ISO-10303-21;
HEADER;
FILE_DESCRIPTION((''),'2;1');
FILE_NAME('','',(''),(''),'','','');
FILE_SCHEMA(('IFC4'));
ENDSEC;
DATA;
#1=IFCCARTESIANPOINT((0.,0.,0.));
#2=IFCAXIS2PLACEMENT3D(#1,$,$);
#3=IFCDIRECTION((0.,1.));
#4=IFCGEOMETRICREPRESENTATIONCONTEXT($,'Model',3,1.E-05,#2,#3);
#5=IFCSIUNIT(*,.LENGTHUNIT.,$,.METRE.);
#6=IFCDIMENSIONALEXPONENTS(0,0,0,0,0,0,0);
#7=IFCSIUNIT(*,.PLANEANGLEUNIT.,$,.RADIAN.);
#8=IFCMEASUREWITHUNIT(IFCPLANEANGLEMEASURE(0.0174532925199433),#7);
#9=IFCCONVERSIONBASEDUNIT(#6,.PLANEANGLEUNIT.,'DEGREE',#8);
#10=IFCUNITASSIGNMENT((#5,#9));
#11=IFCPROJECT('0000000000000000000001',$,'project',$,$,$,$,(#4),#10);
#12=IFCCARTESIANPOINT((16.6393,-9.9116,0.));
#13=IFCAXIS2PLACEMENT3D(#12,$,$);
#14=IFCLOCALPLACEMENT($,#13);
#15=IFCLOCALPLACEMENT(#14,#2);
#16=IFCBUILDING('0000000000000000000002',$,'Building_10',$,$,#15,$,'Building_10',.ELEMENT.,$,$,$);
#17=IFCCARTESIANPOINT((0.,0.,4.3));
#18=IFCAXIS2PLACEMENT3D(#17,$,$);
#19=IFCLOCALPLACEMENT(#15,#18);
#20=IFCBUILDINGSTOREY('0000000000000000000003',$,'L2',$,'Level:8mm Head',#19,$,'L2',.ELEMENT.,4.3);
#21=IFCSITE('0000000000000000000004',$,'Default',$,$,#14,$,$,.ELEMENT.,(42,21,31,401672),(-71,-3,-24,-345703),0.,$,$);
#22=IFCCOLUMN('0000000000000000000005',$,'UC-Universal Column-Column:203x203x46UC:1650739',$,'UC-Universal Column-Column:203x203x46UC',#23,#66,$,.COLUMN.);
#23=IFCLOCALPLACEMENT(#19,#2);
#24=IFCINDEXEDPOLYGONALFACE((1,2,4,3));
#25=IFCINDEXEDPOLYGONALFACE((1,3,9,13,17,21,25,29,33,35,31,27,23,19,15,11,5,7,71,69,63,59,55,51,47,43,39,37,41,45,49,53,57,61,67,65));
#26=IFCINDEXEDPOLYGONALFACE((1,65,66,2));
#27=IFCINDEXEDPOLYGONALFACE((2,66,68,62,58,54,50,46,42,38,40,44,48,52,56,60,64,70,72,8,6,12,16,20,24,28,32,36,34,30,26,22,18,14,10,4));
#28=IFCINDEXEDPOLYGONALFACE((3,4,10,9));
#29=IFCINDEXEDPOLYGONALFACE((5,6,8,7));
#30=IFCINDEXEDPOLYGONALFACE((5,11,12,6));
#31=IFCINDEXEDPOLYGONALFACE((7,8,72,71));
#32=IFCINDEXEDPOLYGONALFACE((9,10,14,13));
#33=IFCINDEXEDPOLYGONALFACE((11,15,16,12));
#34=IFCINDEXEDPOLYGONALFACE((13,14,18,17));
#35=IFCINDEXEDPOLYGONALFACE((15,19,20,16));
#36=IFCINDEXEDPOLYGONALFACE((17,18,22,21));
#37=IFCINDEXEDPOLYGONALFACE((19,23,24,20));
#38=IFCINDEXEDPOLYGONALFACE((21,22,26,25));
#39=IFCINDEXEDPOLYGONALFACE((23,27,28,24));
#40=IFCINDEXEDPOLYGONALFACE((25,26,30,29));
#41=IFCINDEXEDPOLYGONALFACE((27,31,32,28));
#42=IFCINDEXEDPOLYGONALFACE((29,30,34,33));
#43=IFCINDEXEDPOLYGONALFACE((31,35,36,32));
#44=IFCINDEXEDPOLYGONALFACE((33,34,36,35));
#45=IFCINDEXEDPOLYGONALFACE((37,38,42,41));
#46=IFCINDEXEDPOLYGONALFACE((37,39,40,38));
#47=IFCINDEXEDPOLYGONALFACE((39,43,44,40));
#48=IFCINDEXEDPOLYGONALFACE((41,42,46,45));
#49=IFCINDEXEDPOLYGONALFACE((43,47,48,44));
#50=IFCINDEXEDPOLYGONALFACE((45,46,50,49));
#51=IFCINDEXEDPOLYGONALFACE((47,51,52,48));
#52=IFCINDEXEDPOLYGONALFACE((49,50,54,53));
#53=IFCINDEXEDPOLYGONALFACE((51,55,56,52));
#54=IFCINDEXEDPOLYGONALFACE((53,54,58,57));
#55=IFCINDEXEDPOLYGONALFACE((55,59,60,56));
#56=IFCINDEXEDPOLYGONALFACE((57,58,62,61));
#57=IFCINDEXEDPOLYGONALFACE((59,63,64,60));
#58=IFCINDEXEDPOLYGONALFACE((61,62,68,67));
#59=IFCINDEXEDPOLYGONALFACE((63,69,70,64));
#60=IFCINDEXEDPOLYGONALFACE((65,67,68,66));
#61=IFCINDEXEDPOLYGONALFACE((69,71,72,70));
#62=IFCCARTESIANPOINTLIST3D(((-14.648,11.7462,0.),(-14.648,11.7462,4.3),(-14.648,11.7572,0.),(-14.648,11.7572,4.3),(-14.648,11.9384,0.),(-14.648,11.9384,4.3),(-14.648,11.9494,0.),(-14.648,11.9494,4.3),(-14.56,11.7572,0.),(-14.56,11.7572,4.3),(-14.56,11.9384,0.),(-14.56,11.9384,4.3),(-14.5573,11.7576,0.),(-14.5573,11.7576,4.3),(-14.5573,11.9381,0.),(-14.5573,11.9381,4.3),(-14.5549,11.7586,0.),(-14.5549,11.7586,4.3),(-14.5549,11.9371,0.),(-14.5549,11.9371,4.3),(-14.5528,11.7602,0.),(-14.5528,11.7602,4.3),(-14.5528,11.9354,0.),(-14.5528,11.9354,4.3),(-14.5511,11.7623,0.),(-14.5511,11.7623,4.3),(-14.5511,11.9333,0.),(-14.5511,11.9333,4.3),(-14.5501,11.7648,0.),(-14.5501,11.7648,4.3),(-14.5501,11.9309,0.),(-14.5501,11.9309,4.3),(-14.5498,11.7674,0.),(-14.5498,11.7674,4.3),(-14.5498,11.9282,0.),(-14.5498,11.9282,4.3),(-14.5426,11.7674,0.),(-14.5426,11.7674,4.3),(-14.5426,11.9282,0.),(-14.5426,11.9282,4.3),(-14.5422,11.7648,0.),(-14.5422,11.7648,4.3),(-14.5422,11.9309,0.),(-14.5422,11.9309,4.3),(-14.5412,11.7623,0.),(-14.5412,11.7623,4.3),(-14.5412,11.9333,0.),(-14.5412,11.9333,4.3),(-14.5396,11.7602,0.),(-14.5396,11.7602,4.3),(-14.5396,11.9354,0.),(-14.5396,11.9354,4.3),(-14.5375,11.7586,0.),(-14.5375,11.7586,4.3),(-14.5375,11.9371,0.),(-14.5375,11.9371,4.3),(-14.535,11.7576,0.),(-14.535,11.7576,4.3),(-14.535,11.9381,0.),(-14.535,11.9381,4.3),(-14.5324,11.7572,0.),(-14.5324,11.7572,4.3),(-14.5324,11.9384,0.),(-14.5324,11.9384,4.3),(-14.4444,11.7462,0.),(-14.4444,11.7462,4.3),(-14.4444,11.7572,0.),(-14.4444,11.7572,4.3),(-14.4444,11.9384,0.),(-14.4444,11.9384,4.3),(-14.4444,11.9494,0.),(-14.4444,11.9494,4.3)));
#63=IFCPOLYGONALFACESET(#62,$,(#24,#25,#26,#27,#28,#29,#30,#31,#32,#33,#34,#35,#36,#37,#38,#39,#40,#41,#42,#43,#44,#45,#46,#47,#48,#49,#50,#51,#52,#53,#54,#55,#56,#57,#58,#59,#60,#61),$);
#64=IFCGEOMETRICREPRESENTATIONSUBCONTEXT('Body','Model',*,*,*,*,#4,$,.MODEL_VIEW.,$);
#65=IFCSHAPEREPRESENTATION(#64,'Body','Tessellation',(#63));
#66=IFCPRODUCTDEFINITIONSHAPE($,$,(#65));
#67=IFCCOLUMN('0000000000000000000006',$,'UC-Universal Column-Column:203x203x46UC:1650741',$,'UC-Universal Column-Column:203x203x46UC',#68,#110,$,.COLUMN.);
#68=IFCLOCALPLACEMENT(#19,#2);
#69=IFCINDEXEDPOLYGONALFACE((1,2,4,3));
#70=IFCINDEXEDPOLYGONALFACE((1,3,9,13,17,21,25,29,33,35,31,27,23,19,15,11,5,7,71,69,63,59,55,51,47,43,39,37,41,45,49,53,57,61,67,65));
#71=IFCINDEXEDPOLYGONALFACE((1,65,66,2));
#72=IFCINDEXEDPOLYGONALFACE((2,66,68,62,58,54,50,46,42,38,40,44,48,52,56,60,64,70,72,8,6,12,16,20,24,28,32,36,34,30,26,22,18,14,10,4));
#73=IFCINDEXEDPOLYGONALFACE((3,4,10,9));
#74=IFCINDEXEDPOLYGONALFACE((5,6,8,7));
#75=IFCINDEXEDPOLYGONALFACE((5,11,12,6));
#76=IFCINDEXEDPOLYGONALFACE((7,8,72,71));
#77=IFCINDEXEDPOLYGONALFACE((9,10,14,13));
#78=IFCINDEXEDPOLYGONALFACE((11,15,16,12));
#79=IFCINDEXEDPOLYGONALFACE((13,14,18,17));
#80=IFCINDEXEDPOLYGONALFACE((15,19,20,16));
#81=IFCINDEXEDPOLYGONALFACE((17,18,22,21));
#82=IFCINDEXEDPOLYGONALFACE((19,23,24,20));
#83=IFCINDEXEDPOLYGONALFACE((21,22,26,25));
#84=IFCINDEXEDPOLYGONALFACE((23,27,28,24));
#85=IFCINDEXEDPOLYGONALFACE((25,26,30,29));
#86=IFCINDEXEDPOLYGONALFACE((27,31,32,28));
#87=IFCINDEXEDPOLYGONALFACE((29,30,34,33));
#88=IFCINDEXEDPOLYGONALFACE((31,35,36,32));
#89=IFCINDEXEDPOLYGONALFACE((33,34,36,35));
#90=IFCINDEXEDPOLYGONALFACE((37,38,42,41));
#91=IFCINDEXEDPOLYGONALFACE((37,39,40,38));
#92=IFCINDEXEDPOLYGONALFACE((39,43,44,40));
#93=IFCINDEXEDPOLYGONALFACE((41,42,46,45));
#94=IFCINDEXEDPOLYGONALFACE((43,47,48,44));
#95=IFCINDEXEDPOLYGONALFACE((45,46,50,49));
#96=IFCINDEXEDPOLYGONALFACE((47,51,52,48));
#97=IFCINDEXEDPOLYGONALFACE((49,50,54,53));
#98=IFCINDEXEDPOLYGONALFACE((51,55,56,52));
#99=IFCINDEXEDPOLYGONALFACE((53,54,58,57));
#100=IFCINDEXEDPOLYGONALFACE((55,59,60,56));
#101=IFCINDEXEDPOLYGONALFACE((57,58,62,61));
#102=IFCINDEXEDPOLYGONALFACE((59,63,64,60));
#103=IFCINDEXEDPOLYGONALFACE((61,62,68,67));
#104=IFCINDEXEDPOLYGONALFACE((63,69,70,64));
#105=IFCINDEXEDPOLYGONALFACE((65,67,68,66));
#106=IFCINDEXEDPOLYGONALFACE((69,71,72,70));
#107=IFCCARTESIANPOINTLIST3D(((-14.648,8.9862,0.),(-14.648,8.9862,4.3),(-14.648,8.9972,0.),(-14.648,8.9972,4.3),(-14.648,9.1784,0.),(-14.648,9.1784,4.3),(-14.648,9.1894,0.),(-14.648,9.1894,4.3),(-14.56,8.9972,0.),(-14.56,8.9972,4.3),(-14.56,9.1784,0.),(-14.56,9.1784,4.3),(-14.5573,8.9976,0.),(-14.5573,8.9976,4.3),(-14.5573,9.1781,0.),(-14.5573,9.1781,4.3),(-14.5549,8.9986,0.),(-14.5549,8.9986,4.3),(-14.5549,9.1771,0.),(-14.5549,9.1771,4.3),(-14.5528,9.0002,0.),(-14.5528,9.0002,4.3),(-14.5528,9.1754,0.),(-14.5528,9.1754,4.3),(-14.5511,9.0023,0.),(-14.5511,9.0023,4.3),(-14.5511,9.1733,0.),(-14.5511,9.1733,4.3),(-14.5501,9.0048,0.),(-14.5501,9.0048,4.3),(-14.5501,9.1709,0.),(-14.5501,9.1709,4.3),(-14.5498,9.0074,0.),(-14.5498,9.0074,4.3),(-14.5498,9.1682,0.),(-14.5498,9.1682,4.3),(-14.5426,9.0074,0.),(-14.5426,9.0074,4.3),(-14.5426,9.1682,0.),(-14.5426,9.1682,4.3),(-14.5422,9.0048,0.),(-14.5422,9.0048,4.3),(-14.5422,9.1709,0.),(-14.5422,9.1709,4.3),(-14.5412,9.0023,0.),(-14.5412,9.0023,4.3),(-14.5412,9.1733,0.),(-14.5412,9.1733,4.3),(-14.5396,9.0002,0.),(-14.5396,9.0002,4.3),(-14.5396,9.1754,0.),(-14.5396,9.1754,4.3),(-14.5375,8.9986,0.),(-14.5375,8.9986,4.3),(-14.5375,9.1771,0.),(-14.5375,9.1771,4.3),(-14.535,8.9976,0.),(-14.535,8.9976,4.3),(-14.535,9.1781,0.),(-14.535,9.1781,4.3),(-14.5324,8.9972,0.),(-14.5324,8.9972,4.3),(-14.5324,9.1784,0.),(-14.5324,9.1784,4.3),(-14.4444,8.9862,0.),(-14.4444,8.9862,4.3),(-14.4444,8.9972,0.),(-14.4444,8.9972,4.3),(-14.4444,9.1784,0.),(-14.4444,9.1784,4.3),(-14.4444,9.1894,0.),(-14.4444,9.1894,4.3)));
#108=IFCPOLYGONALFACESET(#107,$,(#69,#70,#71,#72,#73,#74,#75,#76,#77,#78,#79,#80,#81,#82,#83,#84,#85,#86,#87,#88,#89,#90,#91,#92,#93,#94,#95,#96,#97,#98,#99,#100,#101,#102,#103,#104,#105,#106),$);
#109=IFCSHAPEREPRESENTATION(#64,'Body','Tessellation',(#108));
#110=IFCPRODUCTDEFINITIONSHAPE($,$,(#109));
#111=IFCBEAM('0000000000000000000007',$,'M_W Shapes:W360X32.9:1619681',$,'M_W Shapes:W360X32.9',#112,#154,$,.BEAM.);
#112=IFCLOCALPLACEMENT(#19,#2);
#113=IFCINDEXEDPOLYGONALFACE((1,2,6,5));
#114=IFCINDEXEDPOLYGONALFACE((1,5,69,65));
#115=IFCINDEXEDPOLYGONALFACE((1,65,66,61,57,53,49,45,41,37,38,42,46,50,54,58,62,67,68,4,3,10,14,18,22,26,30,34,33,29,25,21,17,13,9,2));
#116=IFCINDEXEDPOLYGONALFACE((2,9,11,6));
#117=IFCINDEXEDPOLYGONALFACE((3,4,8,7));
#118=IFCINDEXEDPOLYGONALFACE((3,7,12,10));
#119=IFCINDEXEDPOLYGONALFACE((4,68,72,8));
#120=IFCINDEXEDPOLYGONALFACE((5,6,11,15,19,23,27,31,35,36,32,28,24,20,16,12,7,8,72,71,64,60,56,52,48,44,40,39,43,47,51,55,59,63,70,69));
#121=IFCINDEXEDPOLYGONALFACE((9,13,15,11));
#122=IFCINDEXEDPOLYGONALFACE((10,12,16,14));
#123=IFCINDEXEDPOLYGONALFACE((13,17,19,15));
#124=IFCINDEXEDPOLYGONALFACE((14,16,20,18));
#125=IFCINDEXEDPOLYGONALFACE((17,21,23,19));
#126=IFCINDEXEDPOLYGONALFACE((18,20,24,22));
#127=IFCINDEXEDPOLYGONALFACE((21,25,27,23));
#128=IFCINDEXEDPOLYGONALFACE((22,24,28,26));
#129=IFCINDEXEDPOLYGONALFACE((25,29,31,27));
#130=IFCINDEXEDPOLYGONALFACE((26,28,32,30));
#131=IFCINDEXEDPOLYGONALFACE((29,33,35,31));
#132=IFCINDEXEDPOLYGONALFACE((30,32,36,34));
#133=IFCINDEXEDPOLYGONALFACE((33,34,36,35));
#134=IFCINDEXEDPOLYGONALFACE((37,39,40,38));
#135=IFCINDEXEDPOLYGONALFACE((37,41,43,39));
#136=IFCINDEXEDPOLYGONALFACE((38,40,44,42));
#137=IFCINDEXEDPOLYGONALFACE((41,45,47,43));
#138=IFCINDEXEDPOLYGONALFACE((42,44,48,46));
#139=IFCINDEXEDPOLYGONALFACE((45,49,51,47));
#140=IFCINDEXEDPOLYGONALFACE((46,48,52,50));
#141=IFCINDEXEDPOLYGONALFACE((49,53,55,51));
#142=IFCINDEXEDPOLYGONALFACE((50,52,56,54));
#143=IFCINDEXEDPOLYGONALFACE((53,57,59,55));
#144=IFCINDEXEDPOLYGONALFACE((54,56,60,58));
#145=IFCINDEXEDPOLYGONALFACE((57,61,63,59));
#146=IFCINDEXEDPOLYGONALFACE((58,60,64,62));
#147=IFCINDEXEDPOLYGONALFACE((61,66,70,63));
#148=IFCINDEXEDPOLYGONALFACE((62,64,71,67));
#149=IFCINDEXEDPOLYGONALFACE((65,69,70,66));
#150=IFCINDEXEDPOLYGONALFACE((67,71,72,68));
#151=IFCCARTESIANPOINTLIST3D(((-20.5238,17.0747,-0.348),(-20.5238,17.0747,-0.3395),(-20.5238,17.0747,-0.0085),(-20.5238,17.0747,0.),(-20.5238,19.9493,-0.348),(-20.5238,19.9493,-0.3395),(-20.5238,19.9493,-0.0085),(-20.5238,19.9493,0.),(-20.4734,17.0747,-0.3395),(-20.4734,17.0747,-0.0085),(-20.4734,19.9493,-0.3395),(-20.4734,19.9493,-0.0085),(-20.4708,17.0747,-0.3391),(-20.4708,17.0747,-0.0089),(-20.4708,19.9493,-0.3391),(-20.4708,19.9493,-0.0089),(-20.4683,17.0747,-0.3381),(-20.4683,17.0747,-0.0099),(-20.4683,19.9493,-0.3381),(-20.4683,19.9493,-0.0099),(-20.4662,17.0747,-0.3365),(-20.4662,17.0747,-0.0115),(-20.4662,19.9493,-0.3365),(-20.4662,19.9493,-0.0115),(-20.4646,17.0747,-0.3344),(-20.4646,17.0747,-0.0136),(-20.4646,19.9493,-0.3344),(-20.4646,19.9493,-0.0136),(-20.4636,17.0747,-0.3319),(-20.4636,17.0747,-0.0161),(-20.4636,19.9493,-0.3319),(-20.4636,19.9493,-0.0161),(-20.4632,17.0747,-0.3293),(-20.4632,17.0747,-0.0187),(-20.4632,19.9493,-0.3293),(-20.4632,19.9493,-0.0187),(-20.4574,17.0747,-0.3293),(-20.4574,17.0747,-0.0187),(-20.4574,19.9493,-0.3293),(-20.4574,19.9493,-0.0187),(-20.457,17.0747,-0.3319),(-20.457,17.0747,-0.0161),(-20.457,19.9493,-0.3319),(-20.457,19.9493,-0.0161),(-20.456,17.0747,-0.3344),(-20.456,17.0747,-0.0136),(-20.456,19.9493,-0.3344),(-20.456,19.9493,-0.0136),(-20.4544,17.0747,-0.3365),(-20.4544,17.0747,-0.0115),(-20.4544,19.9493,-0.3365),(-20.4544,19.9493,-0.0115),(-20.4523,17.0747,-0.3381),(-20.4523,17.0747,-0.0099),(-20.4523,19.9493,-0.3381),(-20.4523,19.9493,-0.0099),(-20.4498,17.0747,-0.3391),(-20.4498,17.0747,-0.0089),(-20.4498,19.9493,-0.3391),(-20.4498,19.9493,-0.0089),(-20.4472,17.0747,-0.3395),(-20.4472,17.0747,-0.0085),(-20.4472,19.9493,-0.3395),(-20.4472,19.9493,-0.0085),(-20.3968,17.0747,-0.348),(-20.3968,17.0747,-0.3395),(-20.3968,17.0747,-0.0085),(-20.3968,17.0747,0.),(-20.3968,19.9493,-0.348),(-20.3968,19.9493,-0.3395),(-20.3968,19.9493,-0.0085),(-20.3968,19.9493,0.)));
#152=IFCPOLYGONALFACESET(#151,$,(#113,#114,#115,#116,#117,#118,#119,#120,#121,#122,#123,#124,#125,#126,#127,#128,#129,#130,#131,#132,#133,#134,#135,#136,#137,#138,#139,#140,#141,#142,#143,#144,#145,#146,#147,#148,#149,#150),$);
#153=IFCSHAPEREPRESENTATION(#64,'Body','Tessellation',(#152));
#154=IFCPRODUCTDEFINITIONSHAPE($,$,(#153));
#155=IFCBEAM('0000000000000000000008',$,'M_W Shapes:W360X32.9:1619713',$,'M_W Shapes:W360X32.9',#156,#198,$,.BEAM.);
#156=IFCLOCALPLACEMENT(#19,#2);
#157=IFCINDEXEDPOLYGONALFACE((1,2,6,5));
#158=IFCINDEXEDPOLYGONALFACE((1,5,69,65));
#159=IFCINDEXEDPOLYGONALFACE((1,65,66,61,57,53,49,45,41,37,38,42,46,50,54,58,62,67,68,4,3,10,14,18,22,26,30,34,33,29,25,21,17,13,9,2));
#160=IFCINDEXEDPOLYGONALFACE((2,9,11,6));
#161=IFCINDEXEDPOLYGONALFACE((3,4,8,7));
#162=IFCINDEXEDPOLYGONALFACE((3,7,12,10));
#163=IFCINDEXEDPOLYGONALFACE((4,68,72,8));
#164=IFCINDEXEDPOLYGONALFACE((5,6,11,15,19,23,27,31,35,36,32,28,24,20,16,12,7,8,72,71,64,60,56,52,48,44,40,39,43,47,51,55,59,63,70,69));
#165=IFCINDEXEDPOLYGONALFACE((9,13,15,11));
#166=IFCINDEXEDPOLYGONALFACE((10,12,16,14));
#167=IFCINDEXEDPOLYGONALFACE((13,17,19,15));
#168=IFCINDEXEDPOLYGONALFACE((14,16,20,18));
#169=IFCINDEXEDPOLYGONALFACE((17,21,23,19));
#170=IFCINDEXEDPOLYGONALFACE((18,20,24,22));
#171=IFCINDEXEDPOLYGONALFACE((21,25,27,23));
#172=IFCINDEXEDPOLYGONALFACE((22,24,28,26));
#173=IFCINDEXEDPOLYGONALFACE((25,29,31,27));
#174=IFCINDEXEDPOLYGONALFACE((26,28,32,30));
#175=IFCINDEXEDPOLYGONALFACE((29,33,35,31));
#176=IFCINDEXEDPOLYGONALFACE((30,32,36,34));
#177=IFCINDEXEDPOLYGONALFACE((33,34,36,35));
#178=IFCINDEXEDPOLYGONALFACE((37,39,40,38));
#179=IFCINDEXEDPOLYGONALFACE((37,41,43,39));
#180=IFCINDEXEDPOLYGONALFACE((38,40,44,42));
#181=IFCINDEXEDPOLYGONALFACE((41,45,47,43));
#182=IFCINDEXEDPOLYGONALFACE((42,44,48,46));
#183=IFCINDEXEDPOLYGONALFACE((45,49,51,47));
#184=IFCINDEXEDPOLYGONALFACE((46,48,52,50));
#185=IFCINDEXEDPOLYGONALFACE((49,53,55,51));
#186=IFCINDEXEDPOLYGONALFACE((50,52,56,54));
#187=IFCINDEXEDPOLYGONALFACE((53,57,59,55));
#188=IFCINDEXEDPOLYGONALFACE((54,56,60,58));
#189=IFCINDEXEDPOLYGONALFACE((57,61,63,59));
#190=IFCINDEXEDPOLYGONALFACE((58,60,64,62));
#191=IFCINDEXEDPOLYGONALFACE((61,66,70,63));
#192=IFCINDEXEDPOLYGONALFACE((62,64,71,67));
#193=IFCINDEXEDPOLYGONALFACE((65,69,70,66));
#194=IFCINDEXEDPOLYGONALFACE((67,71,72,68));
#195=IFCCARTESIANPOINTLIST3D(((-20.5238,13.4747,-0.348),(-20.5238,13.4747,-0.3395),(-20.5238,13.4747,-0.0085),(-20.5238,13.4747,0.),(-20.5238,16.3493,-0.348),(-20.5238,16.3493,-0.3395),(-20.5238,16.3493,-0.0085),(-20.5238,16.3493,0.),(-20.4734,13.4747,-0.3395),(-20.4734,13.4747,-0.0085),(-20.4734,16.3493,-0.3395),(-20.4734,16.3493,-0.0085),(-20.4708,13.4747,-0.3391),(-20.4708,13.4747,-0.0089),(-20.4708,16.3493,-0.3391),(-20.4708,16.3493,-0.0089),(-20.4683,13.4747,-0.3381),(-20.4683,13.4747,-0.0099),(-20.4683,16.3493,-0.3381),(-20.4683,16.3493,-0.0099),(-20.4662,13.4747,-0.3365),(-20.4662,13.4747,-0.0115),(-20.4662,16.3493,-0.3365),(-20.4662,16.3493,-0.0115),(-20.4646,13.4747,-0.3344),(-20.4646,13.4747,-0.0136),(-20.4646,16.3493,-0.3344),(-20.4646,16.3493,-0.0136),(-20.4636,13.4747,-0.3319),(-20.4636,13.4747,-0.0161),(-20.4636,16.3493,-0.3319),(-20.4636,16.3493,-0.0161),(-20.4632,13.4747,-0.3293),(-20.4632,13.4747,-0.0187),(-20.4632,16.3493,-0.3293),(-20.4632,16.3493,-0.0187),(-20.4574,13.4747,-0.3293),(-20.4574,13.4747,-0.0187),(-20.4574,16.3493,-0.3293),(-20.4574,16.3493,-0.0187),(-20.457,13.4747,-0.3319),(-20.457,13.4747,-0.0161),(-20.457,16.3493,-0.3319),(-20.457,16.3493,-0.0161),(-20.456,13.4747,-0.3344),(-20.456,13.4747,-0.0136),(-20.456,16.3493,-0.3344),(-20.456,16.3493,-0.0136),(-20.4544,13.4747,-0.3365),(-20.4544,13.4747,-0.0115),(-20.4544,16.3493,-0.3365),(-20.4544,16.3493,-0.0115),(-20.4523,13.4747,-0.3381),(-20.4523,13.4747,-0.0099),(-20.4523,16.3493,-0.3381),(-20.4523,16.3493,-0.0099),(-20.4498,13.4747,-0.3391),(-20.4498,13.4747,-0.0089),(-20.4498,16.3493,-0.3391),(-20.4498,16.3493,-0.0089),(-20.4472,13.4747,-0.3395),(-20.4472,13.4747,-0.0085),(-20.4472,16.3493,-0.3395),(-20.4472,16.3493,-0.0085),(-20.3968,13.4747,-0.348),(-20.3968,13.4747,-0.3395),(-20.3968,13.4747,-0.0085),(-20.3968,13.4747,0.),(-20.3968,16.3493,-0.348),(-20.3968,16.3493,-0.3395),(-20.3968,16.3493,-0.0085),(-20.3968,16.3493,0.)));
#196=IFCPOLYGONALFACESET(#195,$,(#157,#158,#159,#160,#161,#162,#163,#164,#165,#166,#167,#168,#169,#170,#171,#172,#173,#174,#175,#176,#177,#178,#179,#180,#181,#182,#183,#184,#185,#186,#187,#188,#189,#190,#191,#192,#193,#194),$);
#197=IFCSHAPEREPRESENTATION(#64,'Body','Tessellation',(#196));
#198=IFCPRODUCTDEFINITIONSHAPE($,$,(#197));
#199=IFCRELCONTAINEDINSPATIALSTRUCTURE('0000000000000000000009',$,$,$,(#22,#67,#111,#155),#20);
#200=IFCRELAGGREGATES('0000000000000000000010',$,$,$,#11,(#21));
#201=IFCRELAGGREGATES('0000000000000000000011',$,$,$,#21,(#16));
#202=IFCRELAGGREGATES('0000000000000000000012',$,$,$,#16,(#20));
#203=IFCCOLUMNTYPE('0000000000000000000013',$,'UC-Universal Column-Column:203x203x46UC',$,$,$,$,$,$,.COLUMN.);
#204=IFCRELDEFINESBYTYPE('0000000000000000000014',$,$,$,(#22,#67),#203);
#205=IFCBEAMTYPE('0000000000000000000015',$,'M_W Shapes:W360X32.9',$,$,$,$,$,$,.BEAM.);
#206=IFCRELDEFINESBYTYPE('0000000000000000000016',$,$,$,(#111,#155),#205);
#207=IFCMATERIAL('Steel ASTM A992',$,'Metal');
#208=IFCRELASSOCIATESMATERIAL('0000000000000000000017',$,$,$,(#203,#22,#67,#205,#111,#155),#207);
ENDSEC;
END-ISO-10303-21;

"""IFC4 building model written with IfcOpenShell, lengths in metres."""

from ifc_helpers import new_model, entity, si_unit, converted_unit, direction, frame, origin, place, context, subcontext, project, spatial, line, arc, indexed_curve, outline, extrude, source, transform, mapped, material, type_object, type_shapes, element, save


model = new_model("IFC4")

# Units and contexts
model_context = context("Model", 3, precision=1e-05, world=origin(), true_north=direction((0.0, 1.0)))
body_context = subcontext(model_context, "Body", "Model", "MODEL_VIEW")
ifc_project = project(units=[si_unit("LENGTHUNIT", "METRE"), converted_unit("PLANEANGLEUNIT", "DEGREE", entity("IfcPlaneAngleMeasure", 0.0174532925199433), si_unit("PLANEANGLEUNIT", "RADIAN"), dimensions=[0, 0, 0, 0, 0, 0, 0])], contexts=[model_context])

# Site, building, storey
site_placement = place(None, frame((16.6393, -9.9116, 0.0)))
site = spatial("IfcSite", under=ifc_project, at=site_placement, Name="Default", CompositionType="ELEMENT", RefLatitude=(42, 21, 31, 401672), RefLongitude=(-71, -3, -24, -345703), RefElevation=0.0)
building_placement = place(site_placement, origin())
building = spatial("IfcBuilding", under=site, at=building_placement, Name="Building_10", LongName="Building_10", CompositionType="ELEMENT")
storey_placement = place(building_placement, frame((0.0, 0.0, 4.3)))
storey = spatial("IfcBuildingStorey", under=building, at=storey_placement, Name="L2", ObjectType="Level:8mm Head", LongName="L2", CompositionType="ELEMENT", Elevation=4.3)

# Columns
ifc_material_1 = material(Name="Steel ASTM A992", Category="Metal")
column_type_1 = type_object("IfcColumnType", Name="UC-Universal Column-Column:203x203x46UC", PredefinedType="COLUMN", material=ifc_material_1)
shared_shape_1 = source(origin(), body_context, "Body", "SweptSolid", [
    extrude(outline(indexed_curve([(-0.1018, -0.1016), (0.1018, -0.1016), (0.1018, -0.0906), (0.0138, -0.0906), (0.0066, -0.0876), (0.0036, -0.0804), (0.0036, 0.0804), (0.0066, 0.0876), (0.0138, 0.0906), (0.1018, 0.0906), (0.1018, 0.1016), (-0.1018, 0.1016), (-0.1018, 0.0906), (-0.0138, 0.0906), (-0.0066, 0.0876), (-0.0036, 0.0804), (-0.0036, -0.0804), (-0.0066, -0.0876), (-0.0138, -0.0906), (-0.1018, -0.0906)], segments=[line(1, 2, 3, 4), arc(4, 5, 6), line(6, 7), arc(7, 8, 9), line(9, 10, 11, 12, 13, 14), arc(14, 15, 16), line(16, 17), arc(17, 18, 19), line(19, 20, 1)], self_intersect=False)), frame((0.0, 0.0, 4.3), z_axis=(0.0, 0.0, 1.0), x_axis=(-1.0, 0.0, 0.0)), (0.0, 0.0, 1.0), 4.3),
])
type_shapes(column_type_1, [shared_shape_1])
for number, where, name in (
    (1, (-14.5462, 11.8478, -4.3), "UC-Universal Column-Column:203x203x46UC:1650739"),
    (2, (-14.5462, 9.0878, -4.3), "UC-Universal Column-Column:203x203x46UC:1650741"),
):
    element("IfcColumn", number, at=place(storey_placement, frame(where)), inside=storey, type_object=column_type_1, material=ifc_material_1, Name=name, ObjectType="UC-Universal Column-Column:203x203x46UC", PredefinedType="COLUMN", context=body_context, shape_type="MappedRepresentation", body=[
        mapped(shared_shape_1, transform((0.0, 0.0, 0.0), scale=1.0)),
    ])

# Beams
beam_type_1 = type_object("IfcBeamType", Name="M_W Shapes:W360X32.9", PredefinedType="BEAM", material=ifc_material_1)
shared_shape_2 = source(origin(), body_context, "Body", "SweptSolid", [
    extrude(outline(indexed_curve([(-0.0635, -0.1655), (-0.0635, -0.174), (0.0635, -0.174), (0.0635, -0.1655), (0.0131, -0.1655), (0.0059, -0.1625), (0.0029, -0.1553), (0.0029, 0.1553), (0.0059, 0.1625), (0.0131, 0.1655), (0.0635, 0.1655), (0.0635, 0.174), (-0.0635, 0.174), (-0.0635, 0.1655), (-0.0131, 0.1655), (-0.0059, 0.1625), (-0.0029, 0.1553), (-0.0029, -0.1553), (-0.0059, -0.1625), (-0.0131, -0.1655)], segments=[line(1, 2, 3, 4, 5), arc(5, 6, 7), line(7, 8), arc(8, 9, 10), line(10, 11, 12, 13, 14, 15), arc(15, 16, 17), line(17, 18), arc(18, 19, 20), line(20, 1)], self_intersect=False)), frame((-1.4373, 0.0, 0.0), z_axis=(-1.0, 0.0, 0.0), x_axis=(0.0, -1.0, 0.0)), (0.0, 0.0, -1.0), 2.8746),
])
type_shapes(beam_type_1, [shared_shape_2])
for number, where, z_axis, x_axis, name in (
    (3, (-20.4603, 18.512, -0.174), (0.0, 0.0, 1.0), (0.0, -1.0, 0.0), "M_W Shapes:W360X32.9:1619681"),
    (4, (-20.4603, 14.912, -0.174), (0.0, 0.0, 1.0), (0.0, 1.0, 0.0), "M_W Shapes:W360X32.9:1619713"),
):
    element("IfcBeam", number, at=place(storey_placement, frame(where, z_axis=z_axis, x_axis=x_axis)), inside=storey, type_object=beam_type_1, material=ifc_material_1, Name=name, ObjectType="M_W Shapes:W360X32.9", PredefinedType="BEAM", context=body_context, shape_type="MappedRepresentation", body=[
        mapped(shared_shape_2, transform((0.0, 0.0, 0.0), scale=1.0)),
    ])

save(model, "model.ifc")
